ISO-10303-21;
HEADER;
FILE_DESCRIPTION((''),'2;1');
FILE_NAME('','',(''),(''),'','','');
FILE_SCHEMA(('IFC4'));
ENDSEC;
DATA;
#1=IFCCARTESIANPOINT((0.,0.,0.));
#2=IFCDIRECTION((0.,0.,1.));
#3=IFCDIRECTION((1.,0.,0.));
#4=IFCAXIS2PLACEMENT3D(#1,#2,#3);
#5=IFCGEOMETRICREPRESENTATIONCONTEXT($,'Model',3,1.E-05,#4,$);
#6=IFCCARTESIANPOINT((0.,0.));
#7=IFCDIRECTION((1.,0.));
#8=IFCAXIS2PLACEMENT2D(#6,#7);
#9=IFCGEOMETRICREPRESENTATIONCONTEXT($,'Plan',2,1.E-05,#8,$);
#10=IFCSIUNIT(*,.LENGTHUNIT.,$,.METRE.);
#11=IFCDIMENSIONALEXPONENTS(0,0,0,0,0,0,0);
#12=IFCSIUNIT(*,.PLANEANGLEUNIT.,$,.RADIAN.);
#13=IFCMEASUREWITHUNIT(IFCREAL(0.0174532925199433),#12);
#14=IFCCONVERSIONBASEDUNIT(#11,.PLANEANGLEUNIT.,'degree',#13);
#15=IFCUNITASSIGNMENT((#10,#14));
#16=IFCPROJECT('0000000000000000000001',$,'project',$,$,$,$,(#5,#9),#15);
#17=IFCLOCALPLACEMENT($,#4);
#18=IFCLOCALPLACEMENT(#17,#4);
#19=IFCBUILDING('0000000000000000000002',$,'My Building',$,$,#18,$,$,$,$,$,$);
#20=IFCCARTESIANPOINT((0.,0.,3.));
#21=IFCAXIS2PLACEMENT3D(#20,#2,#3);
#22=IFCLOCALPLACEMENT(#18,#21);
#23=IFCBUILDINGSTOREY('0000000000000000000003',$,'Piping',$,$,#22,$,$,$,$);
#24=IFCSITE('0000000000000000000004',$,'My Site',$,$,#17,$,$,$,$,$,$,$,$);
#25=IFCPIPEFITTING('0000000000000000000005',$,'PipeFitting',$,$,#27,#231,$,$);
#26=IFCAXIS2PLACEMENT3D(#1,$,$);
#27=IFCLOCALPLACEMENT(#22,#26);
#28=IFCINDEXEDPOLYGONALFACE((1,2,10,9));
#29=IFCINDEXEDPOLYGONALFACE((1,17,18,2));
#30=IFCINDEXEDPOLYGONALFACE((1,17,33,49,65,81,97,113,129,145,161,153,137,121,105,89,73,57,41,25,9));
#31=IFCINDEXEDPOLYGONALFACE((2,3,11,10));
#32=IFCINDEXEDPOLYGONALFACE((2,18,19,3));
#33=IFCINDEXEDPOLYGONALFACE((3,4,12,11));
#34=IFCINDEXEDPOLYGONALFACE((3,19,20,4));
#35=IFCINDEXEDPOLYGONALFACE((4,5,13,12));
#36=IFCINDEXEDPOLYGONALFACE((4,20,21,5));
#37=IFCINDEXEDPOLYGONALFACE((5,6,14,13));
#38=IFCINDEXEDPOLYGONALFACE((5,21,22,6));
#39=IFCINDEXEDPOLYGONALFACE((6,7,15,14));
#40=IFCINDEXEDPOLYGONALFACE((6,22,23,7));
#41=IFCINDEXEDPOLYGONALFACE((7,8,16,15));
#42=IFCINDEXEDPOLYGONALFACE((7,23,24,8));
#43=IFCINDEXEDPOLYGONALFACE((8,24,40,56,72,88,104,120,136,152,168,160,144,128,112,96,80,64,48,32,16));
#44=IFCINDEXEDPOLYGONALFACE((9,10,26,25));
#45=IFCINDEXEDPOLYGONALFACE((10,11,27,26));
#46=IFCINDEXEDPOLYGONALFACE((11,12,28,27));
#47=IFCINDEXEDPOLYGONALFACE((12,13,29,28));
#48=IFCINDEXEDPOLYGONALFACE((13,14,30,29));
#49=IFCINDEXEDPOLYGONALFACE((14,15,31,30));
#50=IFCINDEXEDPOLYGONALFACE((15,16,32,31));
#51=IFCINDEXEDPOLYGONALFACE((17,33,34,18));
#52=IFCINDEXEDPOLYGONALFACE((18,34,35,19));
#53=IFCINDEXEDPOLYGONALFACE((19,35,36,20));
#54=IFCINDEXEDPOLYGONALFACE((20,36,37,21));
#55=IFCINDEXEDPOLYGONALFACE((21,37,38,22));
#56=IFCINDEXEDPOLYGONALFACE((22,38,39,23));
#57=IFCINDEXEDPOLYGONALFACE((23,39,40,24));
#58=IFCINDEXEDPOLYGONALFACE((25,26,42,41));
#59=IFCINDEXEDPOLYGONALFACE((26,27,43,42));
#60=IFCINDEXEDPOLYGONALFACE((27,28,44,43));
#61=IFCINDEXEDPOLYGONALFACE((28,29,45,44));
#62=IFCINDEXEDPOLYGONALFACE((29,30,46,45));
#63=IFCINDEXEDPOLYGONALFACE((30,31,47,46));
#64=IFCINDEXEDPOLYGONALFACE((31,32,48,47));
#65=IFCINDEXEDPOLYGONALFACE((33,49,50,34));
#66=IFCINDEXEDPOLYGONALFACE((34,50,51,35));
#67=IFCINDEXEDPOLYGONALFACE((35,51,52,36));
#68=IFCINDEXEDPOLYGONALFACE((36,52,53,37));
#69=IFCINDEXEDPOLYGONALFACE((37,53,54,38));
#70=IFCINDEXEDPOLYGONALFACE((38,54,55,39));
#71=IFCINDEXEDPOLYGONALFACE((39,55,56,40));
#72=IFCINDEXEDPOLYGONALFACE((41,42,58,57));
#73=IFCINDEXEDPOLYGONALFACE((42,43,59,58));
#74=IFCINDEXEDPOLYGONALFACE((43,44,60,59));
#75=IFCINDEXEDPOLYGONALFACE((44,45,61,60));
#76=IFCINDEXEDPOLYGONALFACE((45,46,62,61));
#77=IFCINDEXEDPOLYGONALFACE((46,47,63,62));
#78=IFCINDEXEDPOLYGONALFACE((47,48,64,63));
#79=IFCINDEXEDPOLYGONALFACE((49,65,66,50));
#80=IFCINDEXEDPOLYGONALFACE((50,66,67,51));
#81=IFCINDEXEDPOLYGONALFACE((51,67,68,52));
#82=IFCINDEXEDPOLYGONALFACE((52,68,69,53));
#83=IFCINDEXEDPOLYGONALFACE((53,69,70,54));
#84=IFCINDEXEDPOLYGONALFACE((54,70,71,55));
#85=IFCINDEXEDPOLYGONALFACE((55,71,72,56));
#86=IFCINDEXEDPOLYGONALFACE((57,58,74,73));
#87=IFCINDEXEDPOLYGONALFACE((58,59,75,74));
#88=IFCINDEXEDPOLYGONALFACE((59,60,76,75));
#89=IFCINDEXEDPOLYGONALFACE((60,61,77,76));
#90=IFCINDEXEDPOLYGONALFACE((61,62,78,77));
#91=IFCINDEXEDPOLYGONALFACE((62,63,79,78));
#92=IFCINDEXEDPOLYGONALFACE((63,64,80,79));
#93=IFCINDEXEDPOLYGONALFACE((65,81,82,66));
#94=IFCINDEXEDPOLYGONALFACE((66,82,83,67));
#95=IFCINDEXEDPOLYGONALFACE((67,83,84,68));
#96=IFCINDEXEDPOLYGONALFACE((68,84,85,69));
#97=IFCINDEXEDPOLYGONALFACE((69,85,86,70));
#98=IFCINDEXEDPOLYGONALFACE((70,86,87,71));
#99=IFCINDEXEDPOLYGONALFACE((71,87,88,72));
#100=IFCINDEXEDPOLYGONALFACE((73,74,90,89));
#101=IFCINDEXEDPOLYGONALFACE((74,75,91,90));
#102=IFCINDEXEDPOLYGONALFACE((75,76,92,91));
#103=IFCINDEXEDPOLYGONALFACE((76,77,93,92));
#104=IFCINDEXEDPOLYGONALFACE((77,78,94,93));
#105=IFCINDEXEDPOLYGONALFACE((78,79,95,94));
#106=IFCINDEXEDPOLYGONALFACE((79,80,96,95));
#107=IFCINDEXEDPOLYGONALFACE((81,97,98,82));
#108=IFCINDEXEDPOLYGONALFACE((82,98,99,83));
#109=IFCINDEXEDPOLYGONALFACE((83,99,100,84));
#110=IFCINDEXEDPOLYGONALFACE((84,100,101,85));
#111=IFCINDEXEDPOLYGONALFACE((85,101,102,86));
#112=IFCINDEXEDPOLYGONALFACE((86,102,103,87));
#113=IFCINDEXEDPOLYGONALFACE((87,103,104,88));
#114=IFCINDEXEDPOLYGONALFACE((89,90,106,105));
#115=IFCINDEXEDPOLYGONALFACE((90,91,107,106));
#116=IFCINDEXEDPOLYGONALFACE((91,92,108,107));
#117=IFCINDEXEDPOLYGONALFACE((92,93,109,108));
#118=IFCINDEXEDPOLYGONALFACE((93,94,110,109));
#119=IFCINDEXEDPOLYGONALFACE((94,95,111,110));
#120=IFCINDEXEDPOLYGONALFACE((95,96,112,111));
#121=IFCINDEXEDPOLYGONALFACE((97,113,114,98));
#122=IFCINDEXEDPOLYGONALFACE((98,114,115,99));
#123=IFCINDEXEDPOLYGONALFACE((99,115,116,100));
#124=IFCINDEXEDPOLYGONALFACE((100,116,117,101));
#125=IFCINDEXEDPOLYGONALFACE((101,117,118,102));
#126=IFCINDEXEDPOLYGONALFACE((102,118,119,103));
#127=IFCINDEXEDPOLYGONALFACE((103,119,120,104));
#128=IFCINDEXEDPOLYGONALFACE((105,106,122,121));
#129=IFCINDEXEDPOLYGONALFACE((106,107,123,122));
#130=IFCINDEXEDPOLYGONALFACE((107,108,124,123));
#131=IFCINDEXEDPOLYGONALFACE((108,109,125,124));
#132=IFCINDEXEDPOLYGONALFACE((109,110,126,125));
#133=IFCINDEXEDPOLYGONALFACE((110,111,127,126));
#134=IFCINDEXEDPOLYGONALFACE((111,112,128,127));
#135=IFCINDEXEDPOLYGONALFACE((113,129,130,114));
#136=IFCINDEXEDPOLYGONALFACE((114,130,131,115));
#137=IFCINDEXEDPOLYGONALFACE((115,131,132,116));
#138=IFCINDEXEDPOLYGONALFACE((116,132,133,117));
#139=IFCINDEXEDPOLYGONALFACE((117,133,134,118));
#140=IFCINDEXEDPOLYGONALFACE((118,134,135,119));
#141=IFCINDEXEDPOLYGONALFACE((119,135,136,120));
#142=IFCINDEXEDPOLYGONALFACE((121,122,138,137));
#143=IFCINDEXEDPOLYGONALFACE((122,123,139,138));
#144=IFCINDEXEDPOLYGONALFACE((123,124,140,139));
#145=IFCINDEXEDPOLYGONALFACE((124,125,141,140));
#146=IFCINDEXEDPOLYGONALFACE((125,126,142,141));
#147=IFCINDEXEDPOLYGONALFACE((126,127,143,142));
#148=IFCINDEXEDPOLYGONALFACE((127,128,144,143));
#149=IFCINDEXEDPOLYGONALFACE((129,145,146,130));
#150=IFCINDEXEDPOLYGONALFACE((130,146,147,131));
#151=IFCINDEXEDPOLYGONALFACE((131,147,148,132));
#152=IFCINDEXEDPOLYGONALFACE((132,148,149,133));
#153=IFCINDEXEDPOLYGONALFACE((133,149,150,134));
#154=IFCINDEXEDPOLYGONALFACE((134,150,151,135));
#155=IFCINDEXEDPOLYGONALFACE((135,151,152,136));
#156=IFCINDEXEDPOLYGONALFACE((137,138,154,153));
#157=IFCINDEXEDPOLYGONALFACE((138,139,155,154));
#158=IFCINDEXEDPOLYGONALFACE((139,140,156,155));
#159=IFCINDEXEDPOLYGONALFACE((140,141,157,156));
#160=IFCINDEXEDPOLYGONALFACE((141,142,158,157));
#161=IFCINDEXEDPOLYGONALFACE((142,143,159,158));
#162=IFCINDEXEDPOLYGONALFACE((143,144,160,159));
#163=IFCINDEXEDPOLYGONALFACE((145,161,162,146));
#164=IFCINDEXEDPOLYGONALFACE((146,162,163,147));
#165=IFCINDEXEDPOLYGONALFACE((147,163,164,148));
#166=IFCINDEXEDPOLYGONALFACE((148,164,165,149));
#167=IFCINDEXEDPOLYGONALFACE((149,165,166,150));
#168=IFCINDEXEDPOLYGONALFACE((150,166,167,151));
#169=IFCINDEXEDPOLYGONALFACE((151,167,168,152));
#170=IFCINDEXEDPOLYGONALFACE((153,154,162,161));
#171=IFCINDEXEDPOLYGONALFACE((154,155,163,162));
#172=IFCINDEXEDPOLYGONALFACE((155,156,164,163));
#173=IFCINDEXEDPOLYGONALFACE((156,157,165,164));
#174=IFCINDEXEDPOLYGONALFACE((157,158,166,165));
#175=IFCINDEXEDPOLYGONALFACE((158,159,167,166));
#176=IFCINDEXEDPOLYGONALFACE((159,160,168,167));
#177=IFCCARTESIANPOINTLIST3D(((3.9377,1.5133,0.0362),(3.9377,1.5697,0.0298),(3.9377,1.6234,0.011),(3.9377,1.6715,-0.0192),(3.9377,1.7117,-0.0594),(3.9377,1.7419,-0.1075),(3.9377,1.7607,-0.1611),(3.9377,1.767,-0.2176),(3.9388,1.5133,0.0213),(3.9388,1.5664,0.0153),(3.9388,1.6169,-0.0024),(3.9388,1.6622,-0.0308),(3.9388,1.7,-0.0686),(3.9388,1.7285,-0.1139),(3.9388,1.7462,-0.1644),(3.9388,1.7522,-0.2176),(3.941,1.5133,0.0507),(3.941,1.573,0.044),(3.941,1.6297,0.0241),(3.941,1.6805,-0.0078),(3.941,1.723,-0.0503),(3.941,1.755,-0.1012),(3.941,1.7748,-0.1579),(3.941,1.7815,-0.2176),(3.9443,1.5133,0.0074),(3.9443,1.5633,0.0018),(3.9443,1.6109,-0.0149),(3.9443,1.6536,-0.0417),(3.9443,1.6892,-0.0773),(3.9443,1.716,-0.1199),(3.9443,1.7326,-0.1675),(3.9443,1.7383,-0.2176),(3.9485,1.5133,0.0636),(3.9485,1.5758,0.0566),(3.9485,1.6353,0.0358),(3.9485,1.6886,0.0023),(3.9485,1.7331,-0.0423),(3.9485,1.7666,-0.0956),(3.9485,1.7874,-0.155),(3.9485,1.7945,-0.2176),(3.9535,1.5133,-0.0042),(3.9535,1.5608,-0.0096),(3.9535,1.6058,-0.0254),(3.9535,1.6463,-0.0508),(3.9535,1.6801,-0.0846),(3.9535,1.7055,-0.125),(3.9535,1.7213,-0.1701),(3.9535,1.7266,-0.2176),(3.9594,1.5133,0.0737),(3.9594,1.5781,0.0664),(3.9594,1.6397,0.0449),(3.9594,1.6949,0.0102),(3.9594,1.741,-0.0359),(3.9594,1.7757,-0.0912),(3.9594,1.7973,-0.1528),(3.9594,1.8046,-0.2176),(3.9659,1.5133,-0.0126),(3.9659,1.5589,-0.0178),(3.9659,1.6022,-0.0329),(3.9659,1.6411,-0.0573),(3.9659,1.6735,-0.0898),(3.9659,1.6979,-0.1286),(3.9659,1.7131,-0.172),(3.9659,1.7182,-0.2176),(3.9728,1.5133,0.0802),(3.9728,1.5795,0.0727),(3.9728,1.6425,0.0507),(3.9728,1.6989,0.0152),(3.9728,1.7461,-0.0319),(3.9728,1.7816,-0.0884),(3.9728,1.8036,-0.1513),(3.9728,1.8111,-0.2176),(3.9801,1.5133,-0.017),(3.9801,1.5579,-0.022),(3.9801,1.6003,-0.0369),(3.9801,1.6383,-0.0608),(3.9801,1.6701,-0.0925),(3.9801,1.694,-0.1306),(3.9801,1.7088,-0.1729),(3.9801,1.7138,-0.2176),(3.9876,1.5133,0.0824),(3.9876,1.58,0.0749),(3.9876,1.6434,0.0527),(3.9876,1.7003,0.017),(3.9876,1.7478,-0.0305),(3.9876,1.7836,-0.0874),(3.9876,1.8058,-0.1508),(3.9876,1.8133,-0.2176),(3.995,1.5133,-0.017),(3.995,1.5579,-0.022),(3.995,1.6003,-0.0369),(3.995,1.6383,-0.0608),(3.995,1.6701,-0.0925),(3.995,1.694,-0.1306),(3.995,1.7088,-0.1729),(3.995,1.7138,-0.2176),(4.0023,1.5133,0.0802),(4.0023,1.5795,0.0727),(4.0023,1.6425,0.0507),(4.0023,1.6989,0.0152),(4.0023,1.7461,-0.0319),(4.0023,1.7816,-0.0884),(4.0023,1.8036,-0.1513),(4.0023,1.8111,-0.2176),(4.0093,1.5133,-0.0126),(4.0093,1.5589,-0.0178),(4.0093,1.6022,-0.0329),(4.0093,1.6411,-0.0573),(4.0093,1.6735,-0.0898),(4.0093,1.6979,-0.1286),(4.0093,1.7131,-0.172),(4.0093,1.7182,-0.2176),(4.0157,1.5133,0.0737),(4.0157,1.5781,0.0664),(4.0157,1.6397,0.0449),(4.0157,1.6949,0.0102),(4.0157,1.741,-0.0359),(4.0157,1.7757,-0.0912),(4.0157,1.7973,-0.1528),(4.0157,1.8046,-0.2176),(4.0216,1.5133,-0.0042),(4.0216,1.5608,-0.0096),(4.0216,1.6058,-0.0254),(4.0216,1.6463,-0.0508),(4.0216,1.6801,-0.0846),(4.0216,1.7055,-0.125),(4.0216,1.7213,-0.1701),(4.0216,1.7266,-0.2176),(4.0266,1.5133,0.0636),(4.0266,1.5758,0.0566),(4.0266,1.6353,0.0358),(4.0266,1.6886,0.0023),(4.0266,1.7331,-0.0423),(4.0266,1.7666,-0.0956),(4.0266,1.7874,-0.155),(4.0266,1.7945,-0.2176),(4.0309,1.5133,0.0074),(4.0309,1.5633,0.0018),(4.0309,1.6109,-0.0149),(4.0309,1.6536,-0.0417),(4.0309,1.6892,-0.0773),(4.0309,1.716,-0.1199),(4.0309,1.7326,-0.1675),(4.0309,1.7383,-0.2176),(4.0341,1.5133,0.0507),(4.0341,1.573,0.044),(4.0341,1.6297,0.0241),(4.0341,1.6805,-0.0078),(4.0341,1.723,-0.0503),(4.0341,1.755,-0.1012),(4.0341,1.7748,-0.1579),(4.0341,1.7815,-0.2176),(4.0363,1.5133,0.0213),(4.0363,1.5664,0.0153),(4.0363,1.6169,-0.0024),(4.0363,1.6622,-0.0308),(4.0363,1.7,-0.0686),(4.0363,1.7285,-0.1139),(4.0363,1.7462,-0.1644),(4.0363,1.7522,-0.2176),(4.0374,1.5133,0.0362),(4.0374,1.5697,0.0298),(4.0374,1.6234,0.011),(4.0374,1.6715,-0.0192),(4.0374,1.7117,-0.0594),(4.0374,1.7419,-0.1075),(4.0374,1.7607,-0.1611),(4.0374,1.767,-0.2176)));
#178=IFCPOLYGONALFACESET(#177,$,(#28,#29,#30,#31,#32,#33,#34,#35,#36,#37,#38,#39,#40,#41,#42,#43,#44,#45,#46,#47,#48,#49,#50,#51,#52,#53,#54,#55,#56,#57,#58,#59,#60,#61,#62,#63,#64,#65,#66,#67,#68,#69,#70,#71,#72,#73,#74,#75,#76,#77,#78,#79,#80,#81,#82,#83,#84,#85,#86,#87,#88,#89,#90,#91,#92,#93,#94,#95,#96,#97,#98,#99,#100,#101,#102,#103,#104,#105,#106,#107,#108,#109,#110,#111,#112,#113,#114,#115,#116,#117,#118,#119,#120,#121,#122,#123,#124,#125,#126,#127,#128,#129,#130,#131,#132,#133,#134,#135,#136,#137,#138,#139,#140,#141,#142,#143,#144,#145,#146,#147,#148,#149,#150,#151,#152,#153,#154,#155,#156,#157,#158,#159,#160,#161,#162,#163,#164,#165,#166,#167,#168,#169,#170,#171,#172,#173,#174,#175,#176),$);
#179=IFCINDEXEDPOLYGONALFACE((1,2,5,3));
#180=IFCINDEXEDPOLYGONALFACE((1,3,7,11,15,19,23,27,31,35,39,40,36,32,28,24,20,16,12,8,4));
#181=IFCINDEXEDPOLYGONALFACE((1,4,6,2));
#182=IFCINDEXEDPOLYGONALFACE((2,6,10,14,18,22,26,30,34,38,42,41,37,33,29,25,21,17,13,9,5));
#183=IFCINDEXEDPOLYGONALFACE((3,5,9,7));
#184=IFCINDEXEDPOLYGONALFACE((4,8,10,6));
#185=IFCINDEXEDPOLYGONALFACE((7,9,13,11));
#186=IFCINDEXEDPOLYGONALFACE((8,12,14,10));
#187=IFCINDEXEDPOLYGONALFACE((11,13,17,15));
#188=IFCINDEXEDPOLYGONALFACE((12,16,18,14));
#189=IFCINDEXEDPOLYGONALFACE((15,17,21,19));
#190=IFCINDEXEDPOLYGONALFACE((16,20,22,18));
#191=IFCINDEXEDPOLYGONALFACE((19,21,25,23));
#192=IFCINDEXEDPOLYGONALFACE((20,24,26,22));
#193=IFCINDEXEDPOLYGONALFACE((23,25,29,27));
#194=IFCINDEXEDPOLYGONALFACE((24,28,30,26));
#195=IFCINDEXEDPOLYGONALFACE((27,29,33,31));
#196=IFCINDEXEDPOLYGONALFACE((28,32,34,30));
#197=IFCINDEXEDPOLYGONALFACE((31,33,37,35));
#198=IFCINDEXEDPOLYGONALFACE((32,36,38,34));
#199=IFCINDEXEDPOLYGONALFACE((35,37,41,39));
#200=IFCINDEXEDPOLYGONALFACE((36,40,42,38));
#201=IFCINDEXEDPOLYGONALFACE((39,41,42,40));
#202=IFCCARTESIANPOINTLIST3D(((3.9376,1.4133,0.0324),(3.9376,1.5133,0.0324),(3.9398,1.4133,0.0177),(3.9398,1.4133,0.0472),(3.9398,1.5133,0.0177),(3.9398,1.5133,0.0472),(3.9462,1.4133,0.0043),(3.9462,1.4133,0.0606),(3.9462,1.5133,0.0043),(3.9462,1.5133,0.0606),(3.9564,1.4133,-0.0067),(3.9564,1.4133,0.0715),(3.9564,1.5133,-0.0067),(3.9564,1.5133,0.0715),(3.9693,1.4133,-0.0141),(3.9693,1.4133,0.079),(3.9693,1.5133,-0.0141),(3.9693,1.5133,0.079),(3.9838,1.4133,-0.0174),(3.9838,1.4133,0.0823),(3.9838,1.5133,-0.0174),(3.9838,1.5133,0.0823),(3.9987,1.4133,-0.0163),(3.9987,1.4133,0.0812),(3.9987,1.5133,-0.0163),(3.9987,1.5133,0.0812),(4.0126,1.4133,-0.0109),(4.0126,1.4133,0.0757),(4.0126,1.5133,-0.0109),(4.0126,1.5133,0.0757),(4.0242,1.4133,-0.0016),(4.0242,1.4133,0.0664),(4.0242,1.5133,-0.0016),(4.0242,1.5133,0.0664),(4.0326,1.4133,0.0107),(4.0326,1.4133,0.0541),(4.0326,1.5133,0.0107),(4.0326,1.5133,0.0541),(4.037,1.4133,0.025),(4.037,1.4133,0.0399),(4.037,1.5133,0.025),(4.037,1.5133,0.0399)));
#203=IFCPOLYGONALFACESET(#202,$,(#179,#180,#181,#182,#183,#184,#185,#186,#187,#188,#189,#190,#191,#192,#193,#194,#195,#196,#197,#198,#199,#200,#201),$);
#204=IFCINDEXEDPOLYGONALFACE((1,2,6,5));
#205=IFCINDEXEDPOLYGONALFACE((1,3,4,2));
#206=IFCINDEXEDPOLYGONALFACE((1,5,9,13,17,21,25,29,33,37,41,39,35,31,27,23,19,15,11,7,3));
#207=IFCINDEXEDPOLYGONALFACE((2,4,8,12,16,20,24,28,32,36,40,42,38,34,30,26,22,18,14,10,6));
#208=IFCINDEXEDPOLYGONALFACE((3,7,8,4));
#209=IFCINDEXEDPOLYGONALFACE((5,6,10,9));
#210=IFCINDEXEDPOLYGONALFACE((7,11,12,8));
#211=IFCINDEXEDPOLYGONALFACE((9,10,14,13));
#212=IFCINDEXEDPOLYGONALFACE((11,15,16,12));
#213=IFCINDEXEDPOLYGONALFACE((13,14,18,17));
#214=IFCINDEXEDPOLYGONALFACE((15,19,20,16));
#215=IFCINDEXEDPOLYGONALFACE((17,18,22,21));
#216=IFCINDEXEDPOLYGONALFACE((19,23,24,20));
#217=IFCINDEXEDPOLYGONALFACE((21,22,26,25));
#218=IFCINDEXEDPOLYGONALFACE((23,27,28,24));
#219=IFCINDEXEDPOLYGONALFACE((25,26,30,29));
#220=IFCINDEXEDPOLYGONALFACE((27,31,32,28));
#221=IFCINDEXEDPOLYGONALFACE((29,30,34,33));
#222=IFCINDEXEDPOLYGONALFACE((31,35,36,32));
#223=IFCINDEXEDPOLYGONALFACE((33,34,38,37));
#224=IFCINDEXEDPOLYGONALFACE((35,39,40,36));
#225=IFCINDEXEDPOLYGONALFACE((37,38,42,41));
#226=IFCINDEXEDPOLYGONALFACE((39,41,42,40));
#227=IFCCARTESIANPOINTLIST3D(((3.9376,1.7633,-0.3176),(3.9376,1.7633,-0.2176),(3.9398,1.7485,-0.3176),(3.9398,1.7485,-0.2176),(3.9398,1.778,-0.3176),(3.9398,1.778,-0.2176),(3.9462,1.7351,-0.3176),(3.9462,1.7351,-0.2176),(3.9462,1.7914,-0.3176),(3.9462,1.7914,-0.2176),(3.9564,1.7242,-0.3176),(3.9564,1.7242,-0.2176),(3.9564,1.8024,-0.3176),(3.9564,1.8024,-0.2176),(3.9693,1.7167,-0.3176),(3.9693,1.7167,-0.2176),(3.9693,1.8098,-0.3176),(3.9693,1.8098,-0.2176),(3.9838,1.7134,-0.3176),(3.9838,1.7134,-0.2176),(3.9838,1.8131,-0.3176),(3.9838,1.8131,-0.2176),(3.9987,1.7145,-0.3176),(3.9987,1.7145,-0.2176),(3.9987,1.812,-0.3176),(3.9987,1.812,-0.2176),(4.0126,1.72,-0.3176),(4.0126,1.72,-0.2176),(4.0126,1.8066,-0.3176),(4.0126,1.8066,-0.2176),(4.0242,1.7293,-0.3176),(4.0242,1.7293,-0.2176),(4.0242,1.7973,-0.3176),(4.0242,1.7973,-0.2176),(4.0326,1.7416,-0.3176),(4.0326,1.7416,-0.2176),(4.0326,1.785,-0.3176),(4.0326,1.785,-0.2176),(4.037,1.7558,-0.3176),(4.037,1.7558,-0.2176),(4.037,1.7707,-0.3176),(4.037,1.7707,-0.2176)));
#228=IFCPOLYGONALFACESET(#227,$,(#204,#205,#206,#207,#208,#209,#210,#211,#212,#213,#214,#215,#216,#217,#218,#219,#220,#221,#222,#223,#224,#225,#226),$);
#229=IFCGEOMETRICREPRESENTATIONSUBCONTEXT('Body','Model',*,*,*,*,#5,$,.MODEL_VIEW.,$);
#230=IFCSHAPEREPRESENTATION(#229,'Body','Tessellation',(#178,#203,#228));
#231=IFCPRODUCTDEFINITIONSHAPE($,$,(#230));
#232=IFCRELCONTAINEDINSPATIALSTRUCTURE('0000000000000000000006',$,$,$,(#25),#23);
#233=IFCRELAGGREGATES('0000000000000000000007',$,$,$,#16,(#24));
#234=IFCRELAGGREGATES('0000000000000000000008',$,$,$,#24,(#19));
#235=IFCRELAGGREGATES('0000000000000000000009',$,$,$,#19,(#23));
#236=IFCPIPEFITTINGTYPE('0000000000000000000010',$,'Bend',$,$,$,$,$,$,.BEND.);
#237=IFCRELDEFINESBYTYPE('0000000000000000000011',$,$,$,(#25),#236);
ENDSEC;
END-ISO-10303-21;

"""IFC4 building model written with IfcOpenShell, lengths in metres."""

from ifc_helpers import new_model, entity, si_unit, converted_unit, frame, origin_with_axes, origin_2d_with_axis, place, context, subcontext, project, spatial, circle, extrude, source, transform, mapped, type_object, type_shapes, element, save


model = new_model("IFC4")

# Units and contexts
model_context = context("Model", 3, precision=1e-05, world=origin_with_axes())
plan_context = context("Plan", 2, precision=1e-05, world=origin_2d_with_axis())
body_context = subcontext(model_context, "Body", "Model", "MODEL_VIEW")
ifc_project = project(units=[si_unit("LENGTHUNIT", "METRE"), converted_unit("PLANEANGLEUNIT", "degree", entity("IfcReal", 0.0174532925199433), si_unit("PLANEANGLEUNIT", "RADIAN"), dimensions=[0, 0, 0, 0, 0, 0, 0])], contexts=[model_context, plan_context])

# Site, building, storey
site_placement = place(None, origin_with_axes())
site = spatial("IfcSite", under=ifc_project, at=site_placement, Name="My Site")
building_placement = place(site_placement, origin_with_axes())
building = spatial("IfcBuilding", under=site, at=building_placement, Name="My Building")
storey_placement = place(building_placement, frame((0.0, 0.0, 3.0), z_axis=(0.0, 0.0, 1.0), x_axis=(1.0, 0.0, 0.0)))
storey = spatial("IfcBuildingStorey", under=building, at=storey_placement, Name="Piping")

# Pipe fitting
pipe_fitting_type_1 = type_object("IfcPipeFittingType", Name="Bend", PredefinedType="BEND")
shared_shape_1 = source(origin_with_axes(), body_context, "Body", "SolidModel", [
    entity("IfcSweptDiskSolid", entity("IfcIndexedPolyCurve", entity("IfcCartesianPointList3D", [[0.0, 0.0, 0.1], [0.0, -0.0732, 0.2768], [0.0, -0.25, 0.35]]), [entity("IfcArcIndex", [1, 2, 3])]), 0.05),
    extrude(circle(Radius=0.05), origin_with_axes(), (0.0, 0.0, 1.0), 0.1),
    extrude(circle(Radius=0.05), frame((0.0, -0.25, 0.35), z_axis=(0.0, -1.0, 0.0), x_axis=(1.0, 0.0, 0.0)), (0.0, 0.0, 1.0), 0.1),
])
type_shapes(pipe_fitting_type_1, [shared_shape_1])
for number, where, z_axis, x_axis, name in (
    (1, (3.9876, 1.4133, 0.0324), (0.0, 1.0, 0.0), (-1.0, 0.0, 0.0), "PipeFitting"),
):
    element("IfcPipeFitting", number, at=place(storey_placement, frame(where, z_axis=z_axis, x_axis=x_axis)), inside=storey, type_object=pipe_fitting_type_1, Name=name, context=body_context, shape_type="MappedRepresentation", body=[
        mapped(shared_shape_1, transform((0.0, 0.0, 0.0), x_axis=(1.0, 0.0, 0.0), y_axis=(0.0, 1.0, 0.0), z_axis=(0.0, 0.0, 1.0), scale=1.0)),
    ])

save(model, "model.ifc")
